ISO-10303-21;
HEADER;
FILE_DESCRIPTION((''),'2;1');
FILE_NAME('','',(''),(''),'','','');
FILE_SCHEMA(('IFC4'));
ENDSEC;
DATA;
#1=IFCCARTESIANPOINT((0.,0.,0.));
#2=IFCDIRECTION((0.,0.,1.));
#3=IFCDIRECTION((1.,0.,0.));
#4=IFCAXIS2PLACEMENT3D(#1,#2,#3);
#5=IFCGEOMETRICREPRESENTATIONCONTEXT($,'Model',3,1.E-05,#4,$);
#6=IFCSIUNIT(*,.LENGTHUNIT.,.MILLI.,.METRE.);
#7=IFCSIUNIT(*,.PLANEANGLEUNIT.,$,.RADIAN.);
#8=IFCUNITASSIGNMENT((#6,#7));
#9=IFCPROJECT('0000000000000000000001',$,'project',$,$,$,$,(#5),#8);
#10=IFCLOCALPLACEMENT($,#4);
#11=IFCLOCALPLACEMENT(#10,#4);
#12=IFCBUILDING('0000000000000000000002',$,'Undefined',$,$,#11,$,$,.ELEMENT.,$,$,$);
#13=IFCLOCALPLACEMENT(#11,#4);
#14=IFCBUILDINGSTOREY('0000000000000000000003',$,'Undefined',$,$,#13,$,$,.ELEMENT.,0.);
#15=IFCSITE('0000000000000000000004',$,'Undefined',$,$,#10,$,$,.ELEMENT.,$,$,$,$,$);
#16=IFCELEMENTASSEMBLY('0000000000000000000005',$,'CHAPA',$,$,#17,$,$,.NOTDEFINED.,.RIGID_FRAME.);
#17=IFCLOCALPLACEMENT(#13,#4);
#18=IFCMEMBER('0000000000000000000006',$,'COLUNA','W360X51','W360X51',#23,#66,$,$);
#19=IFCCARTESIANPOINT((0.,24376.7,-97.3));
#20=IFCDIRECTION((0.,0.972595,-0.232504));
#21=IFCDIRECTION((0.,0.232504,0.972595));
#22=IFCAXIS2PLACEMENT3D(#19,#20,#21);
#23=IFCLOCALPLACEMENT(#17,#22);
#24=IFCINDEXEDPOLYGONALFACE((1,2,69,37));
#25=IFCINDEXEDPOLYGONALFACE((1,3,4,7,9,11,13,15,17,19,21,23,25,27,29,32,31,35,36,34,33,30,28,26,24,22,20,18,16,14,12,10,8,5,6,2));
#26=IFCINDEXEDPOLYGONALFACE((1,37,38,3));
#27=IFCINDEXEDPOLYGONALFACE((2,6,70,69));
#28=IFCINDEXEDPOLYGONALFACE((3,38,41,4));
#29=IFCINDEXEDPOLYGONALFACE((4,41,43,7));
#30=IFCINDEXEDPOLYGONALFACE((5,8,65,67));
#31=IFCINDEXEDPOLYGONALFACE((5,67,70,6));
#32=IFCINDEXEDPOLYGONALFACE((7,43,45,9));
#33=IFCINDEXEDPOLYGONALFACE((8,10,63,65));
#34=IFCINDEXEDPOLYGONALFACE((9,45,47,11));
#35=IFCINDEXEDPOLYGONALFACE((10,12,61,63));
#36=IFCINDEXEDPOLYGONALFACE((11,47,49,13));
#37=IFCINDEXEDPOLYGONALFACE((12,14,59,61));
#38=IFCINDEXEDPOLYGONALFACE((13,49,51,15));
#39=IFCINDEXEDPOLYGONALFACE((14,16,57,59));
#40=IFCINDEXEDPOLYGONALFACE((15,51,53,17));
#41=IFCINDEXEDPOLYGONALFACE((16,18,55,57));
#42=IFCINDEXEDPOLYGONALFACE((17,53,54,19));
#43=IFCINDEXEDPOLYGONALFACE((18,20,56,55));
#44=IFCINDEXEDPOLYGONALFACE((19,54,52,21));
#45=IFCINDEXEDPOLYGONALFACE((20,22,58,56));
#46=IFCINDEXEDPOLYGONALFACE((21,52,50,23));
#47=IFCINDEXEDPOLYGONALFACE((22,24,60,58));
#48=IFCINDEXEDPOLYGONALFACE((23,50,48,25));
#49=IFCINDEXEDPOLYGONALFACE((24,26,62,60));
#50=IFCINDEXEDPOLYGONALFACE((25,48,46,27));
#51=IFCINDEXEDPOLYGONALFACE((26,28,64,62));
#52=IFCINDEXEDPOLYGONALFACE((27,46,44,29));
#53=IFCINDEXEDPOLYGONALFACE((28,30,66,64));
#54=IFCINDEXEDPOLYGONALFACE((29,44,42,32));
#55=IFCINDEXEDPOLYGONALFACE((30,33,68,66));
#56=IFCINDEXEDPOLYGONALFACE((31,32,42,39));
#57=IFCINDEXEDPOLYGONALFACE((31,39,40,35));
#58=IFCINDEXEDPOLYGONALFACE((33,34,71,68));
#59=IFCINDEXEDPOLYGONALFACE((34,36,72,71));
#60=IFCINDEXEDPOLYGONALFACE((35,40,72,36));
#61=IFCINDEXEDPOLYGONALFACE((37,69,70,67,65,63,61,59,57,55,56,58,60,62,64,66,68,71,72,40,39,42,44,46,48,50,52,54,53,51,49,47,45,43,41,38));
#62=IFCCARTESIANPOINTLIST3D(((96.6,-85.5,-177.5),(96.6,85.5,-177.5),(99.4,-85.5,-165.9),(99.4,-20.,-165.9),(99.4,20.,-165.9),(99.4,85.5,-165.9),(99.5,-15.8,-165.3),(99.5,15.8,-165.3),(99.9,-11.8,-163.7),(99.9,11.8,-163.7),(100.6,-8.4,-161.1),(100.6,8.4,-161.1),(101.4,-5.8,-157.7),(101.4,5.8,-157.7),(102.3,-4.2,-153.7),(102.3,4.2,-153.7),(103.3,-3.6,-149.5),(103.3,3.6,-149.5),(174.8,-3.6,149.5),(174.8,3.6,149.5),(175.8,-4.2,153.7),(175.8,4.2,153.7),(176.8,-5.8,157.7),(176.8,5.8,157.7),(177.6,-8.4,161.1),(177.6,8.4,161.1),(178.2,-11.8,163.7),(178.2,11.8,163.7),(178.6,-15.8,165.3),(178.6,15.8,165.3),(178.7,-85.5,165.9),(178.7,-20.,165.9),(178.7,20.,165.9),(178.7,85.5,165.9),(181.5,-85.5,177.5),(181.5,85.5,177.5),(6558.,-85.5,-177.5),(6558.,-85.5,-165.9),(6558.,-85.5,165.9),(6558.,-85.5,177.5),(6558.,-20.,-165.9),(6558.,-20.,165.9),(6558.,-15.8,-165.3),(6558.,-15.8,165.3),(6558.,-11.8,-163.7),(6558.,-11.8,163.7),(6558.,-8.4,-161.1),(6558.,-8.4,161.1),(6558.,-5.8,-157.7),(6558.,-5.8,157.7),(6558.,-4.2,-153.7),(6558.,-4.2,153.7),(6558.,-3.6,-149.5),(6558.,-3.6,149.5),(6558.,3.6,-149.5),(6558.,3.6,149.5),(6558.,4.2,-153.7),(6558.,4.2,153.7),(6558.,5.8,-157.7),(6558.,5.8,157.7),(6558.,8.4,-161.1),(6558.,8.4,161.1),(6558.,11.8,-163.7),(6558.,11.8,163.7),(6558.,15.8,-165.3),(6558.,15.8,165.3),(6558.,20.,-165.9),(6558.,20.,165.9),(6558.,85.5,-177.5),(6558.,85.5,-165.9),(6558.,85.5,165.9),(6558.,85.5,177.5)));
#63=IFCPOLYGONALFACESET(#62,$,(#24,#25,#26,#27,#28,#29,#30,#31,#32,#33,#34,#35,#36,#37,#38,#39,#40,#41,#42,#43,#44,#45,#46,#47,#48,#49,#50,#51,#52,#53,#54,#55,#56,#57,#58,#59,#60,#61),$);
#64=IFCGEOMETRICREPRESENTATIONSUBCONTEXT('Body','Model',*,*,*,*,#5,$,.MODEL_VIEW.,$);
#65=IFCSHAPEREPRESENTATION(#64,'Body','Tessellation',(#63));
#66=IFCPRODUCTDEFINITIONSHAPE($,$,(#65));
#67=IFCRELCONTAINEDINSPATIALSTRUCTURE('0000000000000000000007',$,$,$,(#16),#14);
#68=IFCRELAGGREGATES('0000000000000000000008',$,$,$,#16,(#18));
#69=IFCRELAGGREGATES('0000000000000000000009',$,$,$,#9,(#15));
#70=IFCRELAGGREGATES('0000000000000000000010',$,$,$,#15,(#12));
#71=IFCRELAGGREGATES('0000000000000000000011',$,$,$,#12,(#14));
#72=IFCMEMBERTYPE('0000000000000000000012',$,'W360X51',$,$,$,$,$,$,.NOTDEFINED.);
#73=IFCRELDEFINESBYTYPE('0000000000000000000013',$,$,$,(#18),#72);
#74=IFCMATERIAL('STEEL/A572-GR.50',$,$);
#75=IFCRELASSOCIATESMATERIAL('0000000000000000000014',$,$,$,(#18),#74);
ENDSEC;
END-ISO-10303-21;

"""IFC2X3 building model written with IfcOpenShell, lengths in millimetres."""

from ifc_helpers import new_model, si_unit, frame, origin_with_axes, origin_2d_with_axis, place, context, subcontext, project, spatial, i_section, extrude, clip, halfspace, material, type_object, element, aggregate, save


model = new_model("IFC2X3")

# Units and contexts
model_context = context("Model", 3, precision=1e-05, world=origin_with_axes())
body_context = subcontext(model_context, "Body", "Model", "MODEL_VIEW")
ifc_project = project(units=[si_unit("LENGTHUNIT", "METRE", prefix="MILLI"), si_unit("PLANEANGLEUNIT", "RADIAN")], contexts=[model_context])

# Site, building, storey
site_placement = place(None, origin_with_axes())
site = spatial("IfcSite", under=ifc_project, at=site_placement, Name="Undefined", CompositionType="ELEMENT")
building_placement = place(site_placement, origin_with_axes())
building = spatial("IfcBuilding", under=site, at=building_placement, Name="Undefined", CompositionType="ELEMENT")
storey_placement = place(building_placement, origin_with_axes())
storey = spatial("IfcBuildingStorey", under=building, at=storey_placement, Name="Undefined", CompositionType="ELEMENT", Elevation=0.0)

# Element assembly, member
assembly_1_placement = place(storey_placement, origin_with_axes())
assembly_1 = element("IfcElementAssembly", 1, at=assembly_1_placement, inside=storey, Name="CHAPA", AssemblyPlace="NOTDEFINED", PredefinedType="RIGID_FRAME")
ifc_material_1 = material(Name="STEEL/A572-GR.50")
member_type = type_object("IfcMemberType", Name="W360X51", PredefinedType="NOTDEFINED")
member_placement = place(assembly_1_placement, frame((0.0, 24376.7, -97.3), z_axis=(0.0, 0.972595, -0.232504), x_axis=(0.0, 0.232504, 0.972595)))
member = element("IfcMember", 2, at=member_placement, type_object=member_type, material=ifc_material_1, Name="COLUNA", Description="W360X51", ObjectType="W360X51", context=body_context, shape_type="Clipping", body=[
    clip(clip(extrude(i_section(OverallWidth=171.0, OverallDepth=355.0, WebThickness=7.2, FlangeThickness=11.6, FilletRadius=16.4, at=origin_2d_with_axis()), frame((6558.0, 0.0, 0.0), z_axis=(-1.0, 0.0, 0.0), x_axis=(0.0, -1.0, 0.0)), (0.0, 0.0, 1.0), 6542.9), halfspace(frame((94.5, -85.5, -186.3), z_axis=(-0.972595, 0.0, 0.232504), x_axis=(0.0, 1.0, 0.0)), False)), halfspace(frame((96.6, 0.0, -177.5), z_axis=(0.972595, 0.0, -0.232504), x_axis=(0.0, -1.0, 0.0)), True)),
])

aggregate(assembly_1, [member])

save(model, "model.ifc")
